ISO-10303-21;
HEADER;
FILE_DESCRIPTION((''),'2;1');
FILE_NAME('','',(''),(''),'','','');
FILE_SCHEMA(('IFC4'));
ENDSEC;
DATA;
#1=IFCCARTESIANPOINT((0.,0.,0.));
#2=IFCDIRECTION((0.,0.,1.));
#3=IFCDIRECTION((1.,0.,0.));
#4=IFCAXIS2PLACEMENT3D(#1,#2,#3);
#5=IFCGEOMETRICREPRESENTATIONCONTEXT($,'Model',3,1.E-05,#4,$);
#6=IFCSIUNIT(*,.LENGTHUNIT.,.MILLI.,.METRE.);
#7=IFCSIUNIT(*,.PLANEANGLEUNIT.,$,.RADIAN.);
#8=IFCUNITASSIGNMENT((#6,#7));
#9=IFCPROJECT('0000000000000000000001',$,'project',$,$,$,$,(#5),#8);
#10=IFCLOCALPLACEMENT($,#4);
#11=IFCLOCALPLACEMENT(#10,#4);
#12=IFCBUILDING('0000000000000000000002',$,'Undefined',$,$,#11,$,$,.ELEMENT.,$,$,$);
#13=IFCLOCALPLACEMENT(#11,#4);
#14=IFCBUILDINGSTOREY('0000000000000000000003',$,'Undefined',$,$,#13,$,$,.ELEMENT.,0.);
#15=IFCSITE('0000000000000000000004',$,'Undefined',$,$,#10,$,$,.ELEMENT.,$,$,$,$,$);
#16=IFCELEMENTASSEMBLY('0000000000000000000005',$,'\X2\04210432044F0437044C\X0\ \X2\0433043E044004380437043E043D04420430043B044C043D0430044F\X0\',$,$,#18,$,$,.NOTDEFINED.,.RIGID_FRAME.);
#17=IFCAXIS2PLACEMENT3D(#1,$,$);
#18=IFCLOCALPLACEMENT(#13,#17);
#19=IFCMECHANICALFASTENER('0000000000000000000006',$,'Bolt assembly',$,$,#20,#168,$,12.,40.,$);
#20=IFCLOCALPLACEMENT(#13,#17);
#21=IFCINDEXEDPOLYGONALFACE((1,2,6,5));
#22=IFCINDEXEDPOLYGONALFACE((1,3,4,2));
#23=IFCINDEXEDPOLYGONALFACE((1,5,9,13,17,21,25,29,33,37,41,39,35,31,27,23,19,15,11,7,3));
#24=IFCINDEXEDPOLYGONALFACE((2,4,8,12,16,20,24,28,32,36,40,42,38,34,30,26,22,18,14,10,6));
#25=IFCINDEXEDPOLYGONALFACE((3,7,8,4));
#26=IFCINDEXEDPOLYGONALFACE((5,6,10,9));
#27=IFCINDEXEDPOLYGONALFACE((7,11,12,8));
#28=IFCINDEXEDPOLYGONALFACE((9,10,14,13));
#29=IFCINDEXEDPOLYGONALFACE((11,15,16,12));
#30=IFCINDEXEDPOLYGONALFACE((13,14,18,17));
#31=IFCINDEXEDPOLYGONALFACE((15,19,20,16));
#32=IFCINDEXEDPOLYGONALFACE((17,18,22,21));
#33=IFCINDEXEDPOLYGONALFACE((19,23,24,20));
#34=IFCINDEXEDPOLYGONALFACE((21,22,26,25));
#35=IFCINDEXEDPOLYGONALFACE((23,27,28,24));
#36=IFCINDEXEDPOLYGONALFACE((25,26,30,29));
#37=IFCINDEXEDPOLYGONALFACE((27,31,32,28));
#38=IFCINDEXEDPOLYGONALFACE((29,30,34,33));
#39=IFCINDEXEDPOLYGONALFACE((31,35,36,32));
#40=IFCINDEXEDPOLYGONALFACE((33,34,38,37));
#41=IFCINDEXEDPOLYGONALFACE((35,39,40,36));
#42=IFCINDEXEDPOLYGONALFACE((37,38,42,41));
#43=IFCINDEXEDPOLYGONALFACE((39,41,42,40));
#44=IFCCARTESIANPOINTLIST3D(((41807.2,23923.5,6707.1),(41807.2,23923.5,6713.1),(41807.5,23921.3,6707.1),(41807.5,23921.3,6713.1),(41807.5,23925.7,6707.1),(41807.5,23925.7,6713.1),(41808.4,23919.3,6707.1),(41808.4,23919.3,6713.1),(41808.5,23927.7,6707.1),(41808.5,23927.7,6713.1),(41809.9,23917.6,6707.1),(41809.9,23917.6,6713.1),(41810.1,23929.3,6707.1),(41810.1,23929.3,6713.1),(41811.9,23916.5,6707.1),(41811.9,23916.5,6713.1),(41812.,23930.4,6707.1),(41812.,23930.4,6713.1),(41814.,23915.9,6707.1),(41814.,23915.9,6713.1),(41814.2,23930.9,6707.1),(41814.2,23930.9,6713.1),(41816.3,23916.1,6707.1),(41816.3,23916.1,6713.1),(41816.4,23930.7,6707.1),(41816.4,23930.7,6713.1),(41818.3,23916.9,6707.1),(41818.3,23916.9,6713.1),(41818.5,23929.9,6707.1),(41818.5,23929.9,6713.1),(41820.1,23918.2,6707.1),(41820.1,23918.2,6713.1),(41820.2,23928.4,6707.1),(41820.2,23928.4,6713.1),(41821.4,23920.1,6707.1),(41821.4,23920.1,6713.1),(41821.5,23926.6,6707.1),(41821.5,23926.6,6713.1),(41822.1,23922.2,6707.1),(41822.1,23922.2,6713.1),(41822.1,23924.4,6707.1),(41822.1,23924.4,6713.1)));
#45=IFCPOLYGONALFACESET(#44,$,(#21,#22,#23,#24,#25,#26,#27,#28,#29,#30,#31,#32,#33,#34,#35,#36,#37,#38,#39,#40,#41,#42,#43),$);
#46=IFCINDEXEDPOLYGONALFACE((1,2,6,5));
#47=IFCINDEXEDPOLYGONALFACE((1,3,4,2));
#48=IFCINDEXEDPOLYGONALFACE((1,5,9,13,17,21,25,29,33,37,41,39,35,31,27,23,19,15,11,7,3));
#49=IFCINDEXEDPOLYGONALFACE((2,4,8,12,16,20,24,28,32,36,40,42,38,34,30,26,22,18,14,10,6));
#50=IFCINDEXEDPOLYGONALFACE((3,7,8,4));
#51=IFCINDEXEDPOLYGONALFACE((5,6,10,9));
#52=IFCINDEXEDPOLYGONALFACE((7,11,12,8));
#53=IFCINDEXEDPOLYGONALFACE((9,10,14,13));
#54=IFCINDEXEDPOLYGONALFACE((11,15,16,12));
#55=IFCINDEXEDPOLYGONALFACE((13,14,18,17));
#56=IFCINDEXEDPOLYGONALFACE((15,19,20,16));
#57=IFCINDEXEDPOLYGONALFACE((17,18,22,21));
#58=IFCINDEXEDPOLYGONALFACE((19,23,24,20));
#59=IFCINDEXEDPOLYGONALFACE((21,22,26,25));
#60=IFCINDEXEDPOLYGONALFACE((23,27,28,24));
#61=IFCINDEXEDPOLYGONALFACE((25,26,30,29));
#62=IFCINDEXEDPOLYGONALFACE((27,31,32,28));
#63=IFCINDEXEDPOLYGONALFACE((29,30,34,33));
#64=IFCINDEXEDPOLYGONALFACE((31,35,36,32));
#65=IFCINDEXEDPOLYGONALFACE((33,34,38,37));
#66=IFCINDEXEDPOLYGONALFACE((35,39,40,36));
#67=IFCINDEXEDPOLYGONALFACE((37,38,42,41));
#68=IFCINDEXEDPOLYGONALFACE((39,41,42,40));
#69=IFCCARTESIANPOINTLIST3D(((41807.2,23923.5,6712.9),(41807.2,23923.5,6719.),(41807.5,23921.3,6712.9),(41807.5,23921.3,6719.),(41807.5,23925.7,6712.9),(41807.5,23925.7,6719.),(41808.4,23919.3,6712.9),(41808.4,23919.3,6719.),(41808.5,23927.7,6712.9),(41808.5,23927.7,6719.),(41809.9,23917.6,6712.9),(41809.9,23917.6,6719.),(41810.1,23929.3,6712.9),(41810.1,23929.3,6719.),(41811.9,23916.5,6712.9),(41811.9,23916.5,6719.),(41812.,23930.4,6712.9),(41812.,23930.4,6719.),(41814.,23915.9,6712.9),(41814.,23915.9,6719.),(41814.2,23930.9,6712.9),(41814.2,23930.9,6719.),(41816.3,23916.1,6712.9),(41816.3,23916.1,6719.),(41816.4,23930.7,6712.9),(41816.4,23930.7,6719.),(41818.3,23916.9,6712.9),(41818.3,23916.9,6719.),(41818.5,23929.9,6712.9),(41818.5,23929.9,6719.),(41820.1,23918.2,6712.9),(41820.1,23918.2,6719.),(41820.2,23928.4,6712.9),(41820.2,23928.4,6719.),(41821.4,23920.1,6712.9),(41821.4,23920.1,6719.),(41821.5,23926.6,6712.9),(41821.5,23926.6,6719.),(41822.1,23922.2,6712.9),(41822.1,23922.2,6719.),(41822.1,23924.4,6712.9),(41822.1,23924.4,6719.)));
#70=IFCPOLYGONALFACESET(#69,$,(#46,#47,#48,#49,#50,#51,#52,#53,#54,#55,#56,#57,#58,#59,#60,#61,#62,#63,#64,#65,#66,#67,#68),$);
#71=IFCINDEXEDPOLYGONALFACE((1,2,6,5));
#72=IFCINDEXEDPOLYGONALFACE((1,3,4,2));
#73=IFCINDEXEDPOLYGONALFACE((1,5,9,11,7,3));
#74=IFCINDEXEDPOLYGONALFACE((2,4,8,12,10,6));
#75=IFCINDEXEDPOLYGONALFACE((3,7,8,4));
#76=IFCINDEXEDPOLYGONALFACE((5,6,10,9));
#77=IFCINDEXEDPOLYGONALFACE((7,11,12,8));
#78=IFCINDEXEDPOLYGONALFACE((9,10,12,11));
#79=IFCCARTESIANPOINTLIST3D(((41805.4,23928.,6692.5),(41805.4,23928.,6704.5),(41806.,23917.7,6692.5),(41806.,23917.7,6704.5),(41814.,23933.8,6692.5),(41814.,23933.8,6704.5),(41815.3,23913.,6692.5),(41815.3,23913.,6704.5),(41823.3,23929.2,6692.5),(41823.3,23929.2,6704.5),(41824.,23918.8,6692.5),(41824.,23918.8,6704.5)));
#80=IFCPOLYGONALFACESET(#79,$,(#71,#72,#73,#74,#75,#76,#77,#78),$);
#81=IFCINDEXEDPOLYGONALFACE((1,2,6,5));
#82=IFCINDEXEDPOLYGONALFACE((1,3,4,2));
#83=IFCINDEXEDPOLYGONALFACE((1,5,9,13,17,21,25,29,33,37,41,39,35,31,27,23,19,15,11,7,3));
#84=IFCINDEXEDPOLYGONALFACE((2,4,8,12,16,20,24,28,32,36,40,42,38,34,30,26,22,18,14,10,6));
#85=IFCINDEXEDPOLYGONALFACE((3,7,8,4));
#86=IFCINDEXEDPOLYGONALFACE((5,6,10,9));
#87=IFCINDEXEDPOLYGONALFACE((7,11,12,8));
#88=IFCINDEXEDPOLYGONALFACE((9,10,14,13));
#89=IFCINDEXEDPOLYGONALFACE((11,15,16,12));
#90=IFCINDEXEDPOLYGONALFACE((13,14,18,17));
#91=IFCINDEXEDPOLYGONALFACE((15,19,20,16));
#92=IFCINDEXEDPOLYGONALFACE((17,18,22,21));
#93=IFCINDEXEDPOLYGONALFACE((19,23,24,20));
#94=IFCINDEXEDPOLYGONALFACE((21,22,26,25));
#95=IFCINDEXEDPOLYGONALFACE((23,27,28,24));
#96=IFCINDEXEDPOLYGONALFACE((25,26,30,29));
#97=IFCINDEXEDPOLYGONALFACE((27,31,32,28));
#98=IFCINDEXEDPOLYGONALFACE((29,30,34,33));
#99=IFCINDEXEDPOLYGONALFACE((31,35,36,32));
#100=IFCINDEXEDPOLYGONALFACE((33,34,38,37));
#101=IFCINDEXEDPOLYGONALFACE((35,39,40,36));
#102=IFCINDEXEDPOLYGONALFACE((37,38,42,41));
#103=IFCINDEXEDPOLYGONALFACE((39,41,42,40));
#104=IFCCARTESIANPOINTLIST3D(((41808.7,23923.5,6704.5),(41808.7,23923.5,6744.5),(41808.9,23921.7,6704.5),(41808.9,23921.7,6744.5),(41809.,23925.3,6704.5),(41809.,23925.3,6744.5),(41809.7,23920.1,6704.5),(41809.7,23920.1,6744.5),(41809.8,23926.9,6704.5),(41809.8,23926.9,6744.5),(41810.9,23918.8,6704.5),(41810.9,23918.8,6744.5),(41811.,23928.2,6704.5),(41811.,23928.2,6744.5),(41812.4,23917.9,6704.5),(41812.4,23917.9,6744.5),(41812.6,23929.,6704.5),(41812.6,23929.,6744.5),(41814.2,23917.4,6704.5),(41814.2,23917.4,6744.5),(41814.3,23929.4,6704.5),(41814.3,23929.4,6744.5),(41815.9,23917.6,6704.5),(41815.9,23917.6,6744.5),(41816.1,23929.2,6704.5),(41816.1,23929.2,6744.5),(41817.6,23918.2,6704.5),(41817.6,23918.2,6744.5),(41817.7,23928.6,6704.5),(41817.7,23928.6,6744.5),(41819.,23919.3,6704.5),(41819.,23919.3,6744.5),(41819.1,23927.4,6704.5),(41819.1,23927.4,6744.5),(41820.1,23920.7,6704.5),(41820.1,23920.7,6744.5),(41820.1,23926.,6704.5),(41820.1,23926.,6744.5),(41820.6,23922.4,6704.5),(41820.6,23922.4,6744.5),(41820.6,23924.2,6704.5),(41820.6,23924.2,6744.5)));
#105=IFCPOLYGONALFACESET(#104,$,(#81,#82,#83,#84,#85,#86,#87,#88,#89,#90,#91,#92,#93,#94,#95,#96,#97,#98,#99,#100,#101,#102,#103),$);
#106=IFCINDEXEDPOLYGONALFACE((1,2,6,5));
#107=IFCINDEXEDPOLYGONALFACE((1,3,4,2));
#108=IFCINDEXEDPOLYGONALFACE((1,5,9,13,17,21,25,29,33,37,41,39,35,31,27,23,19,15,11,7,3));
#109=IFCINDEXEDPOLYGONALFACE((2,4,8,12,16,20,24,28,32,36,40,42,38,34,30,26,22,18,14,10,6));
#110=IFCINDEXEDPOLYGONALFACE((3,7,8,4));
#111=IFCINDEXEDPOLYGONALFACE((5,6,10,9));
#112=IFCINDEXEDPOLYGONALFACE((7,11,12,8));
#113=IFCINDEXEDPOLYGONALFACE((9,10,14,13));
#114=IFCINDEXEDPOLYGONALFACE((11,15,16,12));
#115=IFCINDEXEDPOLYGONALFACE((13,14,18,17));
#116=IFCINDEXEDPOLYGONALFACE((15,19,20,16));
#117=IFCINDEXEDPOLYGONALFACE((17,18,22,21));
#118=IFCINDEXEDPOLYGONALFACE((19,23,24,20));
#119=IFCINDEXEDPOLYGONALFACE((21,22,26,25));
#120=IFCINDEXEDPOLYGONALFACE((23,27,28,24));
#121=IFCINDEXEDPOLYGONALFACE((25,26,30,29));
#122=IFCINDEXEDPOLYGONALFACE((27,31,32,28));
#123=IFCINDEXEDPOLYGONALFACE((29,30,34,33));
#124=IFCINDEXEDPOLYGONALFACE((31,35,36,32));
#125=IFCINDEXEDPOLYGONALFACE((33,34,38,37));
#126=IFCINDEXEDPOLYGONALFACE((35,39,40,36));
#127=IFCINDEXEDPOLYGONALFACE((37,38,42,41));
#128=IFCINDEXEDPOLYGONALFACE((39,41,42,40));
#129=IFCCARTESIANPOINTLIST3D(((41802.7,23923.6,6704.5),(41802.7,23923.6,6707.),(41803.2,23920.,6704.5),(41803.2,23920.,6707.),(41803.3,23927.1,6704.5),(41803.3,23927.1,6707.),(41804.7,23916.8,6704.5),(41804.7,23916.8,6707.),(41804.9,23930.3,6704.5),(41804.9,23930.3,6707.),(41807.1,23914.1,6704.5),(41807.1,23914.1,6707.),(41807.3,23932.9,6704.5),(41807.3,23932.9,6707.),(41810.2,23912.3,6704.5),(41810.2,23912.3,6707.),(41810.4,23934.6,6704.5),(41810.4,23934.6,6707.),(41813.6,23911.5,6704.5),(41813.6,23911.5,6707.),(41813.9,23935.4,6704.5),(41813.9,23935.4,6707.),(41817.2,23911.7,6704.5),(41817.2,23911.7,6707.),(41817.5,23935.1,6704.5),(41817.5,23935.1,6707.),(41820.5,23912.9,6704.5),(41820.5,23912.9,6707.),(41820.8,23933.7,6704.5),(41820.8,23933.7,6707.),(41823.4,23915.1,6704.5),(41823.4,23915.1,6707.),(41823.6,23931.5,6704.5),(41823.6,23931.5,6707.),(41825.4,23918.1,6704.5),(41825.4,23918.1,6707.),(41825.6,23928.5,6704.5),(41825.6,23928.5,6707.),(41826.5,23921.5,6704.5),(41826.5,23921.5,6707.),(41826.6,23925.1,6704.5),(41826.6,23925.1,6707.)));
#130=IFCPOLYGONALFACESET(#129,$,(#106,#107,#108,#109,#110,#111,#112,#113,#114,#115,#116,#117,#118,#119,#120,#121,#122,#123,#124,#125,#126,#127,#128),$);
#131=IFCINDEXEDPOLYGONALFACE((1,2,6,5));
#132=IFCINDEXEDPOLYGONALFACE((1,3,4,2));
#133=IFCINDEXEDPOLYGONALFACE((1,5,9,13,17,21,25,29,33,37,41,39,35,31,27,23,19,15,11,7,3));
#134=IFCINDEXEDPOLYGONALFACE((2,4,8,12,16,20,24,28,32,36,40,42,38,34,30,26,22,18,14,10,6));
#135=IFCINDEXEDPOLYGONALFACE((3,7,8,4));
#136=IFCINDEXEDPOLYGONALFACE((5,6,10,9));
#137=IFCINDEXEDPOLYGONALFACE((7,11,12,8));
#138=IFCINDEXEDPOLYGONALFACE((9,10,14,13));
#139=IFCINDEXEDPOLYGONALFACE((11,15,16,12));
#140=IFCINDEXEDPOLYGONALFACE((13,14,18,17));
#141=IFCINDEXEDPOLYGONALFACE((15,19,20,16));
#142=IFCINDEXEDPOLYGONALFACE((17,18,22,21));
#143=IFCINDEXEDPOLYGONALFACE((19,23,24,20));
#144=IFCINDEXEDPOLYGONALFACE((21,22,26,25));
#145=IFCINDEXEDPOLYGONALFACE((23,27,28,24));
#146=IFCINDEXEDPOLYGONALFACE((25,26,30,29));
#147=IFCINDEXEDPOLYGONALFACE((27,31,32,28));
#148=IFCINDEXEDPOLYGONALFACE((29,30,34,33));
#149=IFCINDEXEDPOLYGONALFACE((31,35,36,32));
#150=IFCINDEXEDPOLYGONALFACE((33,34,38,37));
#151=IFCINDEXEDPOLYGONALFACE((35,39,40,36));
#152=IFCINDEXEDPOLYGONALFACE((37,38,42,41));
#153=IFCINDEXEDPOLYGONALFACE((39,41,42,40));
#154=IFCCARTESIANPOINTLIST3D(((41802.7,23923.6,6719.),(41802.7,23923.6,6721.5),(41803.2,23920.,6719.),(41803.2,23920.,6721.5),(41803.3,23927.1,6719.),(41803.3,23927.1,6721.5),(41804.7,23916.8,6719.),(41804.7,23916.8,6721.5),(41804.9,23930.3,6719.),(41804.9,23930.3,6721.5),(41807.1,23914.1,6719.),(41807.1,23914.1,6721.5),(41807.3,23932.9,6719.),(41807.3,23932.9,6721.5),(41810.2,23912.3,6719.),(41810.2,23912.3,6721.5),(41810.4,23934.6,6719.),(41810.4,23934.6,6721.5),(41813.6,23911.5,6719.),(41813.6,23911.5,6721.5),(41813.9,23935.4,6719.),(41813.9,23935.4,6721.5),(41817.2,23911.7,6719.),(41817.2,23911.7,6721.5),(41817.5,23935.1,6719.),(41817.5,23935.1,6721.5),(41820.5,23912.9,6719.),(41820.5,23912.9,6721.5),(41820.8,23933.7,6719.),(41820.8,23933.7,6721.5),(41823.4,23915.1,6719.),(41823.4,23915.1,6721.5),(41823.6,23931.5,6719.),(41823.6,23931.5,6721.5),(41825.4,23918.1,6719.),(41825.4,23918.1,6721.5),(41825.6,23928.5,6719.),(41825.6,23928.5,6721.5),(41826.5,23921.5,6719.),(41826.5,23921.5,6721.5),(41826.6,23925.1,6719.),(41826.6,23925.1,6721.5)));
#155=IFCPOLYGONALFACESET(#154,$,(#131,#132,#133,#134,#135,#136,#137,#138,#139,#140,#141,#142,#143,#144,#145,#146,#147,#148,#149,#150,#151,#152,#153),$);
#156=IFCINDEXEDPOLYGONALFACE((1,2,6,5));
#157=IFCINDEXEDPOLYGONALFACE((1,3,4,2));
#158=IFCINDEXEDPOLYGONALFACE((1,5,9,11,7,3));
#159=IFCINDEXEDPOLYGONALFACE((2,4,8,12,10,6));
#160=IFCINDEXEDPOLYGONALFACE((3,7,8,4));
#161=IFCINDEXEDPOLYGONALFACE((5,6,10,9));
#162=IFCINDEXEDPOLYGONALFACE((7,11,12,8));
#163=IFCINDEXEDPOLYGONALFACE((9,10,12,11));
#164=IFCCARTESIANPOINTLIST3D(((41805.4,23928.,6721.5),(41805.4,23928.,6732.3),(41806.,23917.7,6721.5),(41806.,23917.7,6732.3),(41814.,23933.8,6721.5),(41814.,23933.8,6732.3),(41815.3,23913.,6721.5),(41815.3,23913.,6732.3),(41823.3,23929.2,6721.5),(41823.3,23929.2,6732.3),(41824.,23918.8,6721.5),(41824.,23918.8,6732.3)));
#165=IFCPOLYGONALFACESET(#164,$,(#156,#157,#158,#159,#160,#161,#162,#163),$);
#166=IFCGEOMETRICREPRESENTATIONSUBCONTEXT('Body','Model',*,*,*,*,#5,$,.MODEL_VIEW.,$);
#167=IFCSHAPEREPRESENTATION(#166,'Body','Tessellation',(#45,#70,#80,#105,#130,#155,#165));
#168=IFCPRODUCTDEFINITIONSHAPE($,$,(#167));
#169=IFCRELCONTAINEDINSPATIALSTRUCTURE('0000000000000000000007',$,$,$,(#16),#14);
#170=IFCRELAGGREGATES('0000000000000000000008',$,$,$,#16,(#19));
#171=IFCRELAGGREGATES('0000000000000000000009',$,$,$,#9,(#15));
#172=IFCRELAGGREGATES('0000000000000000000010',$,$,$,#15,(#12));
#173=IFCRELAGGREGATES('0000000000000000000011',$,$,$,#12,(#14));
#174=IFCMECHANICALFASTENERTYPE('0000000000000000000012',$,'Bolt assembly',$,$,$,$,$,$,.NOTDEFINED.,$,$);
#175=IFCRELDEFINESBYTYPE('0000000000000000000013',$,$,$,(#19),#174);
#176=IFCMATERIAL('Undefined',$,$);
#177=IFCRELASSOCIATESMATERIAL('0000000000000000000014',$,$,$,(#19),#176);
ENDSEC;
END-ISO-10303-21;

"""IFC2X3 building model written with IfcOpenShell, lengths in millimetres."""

from ifc_helpers import new_model, si_unit, frame, origin_with_axes, origin_2d_with_axis, place, context, subcontext, project, spatial, polyline, circle, outline, extrude, source, transform, mapped, material, type_object, element, aggregate, save


model = new_model("IFC2X3")

# Units and contexts
model_context = context("Model", 3, precision=1e-05, world=origin_with_axes())
body_context = subcontext(model_context, "Body", "Model", "MODEL_VIEW")
ifc_project = project(units=[si_unit("LENGTHUNIT", "METRE", prefix="MILLI"), si_unit("PLANEANGLEUNIT", "RADIAN")], contexts=[model_context])

# Site, building, storey
site_placement = place(None, origin_with_axes())
site = spatial("IfcSite", under=ifc_project, at=site_placement, Name="Undefined", CompositionType="ELEMENT")
building_placement = place(site_placement, origin_with_axes())
building = spatial("IfcBuilding", under=site, at=building_placement, Name="Undefined", CompositionType="ELEMENT")
storey_placement = place(building_placement, origin_with_axes())
storey = spatial("IfcBuildingStorey", under=building, at=storey_placement, Name="Undefined", CompositionType="ELEMENT", Elevation=0.0)

# Element assembly
assembly_1_placement = place(storey_placement, origin_with_axes())
assembly_1 = element("IfcElementAssembly", 1, at=assembly_1_placement, inside=storey, Name="Связь горизонтальная", AssemblyPlace="NOTDEFINED", PredefinedType="RIGID_FRAME")

# Mechanical fastener
ifc_material_1 = material(Name="Undefined")
mechanical_fastener_type = type_object("IfcMechanicalFastenerType", Name="Bolt assembly")
shared_shape_1 = source(origin_with_axes(), body_context, "Body", "SweptSolid", [
    extrude(circle(Radius=7.5, at=origin_2d_with_axis()), frame((0.0, 0.1, 0.0), z_axis=(0.0, 1.0, 0.0), x_axis=(1.0, 0.0, 0.0)), (0.0, 0.0, 1.0), 6.0),
    extrude(circle(Radius=7.5, at=origin_2d_with_axis()), frame((0.0, 5.9, 0.0), z_axis=(0.0, 1.0, 0.0), x_axis=(1.0, 0.0, 0.0)), (0.0, 0.0, 1.0), 6.1),
    extrude(outline(polyline([(10.4, 0.0), (5.2, 9.0), (-5.2, 9.0), (-10.4, 0.0), (-5.2, -9.0), (5.2, -9.0), (10.4, 0.0)])), frame((0.0, -14.5, 0.0), z_axis=(0.0, 1.0, 0.0), x_axis=(1.0, 0.0, 0.0)), (0.0, 0.0, 1.0), 12.0),
    extrude(circle(Radius=6.0, at=origin_2d_with_axis()), frame((0.0, -2.5, 0.0), z_axis=(0.0, 1.0, 0.0), x_axis=(1.0, 0.0, 0.0)), (0.0, 0.0, 1.0), 40.0),
    extrude(circle(Radius=12.0, at=origin_2d_with_axis()), frame((0.0, -2.5, 0.0), z_axis=(0.0, 1.0, 0.0), x_axis=(1.0, 0.0, 0.0)), (0.0, 0.0, 1.0), 2.5),
    extrude(circle(Radius=12.0, at=origin_2d_with_axis()), frame((0.0, 12.0, 0.0), z_axis=(0.0, 1.0, 0.0), x_axis=(1.0, 0.0, 0.0)), (0.0, 0.0, 1.0), 2.5),
    extrude(outline(polyline([(10.4, 0.0), (5.2, 9.0), (-5.2, 9.0), (-10.4, 0.0), (-5.2, -9.0), (5.2, -9.0), (10.4, 0.0)])), frame((0.0, 14.5, 0.0), z_axis=(0.0, 1.0, 0.0), x_axis=(1.0, 0.0, 0.0)), (0.0, 0.0, 1.0), 10.8),
])
mechanical_fastener_1_placement = place(assembly_1_placement, frame((41814.7, 23923.4, 6707.0), z_axis=(-0.552695, 0.833383, 0.0), x_axis=(-0.833383, -0.552695, 0.0)))
mechanical_fastener_1 = element("IfcMechanicalFastener", 2, at=mechanical_fastener_1_placement, type_object=mechanical_fastener_type, material=ifc_material_1, Name="Bolt assembly", NominalDiameter=12.0, NominalLength=40.0, context=body_context, shape_type="MappedRepresentation", body=[
    mapped(shared_shape_1, transform((0.0, 0.0, 0.0))),
])
aggregate(assembly_1, [mechanical_fastener_1])

save(model, "model.ifc")
